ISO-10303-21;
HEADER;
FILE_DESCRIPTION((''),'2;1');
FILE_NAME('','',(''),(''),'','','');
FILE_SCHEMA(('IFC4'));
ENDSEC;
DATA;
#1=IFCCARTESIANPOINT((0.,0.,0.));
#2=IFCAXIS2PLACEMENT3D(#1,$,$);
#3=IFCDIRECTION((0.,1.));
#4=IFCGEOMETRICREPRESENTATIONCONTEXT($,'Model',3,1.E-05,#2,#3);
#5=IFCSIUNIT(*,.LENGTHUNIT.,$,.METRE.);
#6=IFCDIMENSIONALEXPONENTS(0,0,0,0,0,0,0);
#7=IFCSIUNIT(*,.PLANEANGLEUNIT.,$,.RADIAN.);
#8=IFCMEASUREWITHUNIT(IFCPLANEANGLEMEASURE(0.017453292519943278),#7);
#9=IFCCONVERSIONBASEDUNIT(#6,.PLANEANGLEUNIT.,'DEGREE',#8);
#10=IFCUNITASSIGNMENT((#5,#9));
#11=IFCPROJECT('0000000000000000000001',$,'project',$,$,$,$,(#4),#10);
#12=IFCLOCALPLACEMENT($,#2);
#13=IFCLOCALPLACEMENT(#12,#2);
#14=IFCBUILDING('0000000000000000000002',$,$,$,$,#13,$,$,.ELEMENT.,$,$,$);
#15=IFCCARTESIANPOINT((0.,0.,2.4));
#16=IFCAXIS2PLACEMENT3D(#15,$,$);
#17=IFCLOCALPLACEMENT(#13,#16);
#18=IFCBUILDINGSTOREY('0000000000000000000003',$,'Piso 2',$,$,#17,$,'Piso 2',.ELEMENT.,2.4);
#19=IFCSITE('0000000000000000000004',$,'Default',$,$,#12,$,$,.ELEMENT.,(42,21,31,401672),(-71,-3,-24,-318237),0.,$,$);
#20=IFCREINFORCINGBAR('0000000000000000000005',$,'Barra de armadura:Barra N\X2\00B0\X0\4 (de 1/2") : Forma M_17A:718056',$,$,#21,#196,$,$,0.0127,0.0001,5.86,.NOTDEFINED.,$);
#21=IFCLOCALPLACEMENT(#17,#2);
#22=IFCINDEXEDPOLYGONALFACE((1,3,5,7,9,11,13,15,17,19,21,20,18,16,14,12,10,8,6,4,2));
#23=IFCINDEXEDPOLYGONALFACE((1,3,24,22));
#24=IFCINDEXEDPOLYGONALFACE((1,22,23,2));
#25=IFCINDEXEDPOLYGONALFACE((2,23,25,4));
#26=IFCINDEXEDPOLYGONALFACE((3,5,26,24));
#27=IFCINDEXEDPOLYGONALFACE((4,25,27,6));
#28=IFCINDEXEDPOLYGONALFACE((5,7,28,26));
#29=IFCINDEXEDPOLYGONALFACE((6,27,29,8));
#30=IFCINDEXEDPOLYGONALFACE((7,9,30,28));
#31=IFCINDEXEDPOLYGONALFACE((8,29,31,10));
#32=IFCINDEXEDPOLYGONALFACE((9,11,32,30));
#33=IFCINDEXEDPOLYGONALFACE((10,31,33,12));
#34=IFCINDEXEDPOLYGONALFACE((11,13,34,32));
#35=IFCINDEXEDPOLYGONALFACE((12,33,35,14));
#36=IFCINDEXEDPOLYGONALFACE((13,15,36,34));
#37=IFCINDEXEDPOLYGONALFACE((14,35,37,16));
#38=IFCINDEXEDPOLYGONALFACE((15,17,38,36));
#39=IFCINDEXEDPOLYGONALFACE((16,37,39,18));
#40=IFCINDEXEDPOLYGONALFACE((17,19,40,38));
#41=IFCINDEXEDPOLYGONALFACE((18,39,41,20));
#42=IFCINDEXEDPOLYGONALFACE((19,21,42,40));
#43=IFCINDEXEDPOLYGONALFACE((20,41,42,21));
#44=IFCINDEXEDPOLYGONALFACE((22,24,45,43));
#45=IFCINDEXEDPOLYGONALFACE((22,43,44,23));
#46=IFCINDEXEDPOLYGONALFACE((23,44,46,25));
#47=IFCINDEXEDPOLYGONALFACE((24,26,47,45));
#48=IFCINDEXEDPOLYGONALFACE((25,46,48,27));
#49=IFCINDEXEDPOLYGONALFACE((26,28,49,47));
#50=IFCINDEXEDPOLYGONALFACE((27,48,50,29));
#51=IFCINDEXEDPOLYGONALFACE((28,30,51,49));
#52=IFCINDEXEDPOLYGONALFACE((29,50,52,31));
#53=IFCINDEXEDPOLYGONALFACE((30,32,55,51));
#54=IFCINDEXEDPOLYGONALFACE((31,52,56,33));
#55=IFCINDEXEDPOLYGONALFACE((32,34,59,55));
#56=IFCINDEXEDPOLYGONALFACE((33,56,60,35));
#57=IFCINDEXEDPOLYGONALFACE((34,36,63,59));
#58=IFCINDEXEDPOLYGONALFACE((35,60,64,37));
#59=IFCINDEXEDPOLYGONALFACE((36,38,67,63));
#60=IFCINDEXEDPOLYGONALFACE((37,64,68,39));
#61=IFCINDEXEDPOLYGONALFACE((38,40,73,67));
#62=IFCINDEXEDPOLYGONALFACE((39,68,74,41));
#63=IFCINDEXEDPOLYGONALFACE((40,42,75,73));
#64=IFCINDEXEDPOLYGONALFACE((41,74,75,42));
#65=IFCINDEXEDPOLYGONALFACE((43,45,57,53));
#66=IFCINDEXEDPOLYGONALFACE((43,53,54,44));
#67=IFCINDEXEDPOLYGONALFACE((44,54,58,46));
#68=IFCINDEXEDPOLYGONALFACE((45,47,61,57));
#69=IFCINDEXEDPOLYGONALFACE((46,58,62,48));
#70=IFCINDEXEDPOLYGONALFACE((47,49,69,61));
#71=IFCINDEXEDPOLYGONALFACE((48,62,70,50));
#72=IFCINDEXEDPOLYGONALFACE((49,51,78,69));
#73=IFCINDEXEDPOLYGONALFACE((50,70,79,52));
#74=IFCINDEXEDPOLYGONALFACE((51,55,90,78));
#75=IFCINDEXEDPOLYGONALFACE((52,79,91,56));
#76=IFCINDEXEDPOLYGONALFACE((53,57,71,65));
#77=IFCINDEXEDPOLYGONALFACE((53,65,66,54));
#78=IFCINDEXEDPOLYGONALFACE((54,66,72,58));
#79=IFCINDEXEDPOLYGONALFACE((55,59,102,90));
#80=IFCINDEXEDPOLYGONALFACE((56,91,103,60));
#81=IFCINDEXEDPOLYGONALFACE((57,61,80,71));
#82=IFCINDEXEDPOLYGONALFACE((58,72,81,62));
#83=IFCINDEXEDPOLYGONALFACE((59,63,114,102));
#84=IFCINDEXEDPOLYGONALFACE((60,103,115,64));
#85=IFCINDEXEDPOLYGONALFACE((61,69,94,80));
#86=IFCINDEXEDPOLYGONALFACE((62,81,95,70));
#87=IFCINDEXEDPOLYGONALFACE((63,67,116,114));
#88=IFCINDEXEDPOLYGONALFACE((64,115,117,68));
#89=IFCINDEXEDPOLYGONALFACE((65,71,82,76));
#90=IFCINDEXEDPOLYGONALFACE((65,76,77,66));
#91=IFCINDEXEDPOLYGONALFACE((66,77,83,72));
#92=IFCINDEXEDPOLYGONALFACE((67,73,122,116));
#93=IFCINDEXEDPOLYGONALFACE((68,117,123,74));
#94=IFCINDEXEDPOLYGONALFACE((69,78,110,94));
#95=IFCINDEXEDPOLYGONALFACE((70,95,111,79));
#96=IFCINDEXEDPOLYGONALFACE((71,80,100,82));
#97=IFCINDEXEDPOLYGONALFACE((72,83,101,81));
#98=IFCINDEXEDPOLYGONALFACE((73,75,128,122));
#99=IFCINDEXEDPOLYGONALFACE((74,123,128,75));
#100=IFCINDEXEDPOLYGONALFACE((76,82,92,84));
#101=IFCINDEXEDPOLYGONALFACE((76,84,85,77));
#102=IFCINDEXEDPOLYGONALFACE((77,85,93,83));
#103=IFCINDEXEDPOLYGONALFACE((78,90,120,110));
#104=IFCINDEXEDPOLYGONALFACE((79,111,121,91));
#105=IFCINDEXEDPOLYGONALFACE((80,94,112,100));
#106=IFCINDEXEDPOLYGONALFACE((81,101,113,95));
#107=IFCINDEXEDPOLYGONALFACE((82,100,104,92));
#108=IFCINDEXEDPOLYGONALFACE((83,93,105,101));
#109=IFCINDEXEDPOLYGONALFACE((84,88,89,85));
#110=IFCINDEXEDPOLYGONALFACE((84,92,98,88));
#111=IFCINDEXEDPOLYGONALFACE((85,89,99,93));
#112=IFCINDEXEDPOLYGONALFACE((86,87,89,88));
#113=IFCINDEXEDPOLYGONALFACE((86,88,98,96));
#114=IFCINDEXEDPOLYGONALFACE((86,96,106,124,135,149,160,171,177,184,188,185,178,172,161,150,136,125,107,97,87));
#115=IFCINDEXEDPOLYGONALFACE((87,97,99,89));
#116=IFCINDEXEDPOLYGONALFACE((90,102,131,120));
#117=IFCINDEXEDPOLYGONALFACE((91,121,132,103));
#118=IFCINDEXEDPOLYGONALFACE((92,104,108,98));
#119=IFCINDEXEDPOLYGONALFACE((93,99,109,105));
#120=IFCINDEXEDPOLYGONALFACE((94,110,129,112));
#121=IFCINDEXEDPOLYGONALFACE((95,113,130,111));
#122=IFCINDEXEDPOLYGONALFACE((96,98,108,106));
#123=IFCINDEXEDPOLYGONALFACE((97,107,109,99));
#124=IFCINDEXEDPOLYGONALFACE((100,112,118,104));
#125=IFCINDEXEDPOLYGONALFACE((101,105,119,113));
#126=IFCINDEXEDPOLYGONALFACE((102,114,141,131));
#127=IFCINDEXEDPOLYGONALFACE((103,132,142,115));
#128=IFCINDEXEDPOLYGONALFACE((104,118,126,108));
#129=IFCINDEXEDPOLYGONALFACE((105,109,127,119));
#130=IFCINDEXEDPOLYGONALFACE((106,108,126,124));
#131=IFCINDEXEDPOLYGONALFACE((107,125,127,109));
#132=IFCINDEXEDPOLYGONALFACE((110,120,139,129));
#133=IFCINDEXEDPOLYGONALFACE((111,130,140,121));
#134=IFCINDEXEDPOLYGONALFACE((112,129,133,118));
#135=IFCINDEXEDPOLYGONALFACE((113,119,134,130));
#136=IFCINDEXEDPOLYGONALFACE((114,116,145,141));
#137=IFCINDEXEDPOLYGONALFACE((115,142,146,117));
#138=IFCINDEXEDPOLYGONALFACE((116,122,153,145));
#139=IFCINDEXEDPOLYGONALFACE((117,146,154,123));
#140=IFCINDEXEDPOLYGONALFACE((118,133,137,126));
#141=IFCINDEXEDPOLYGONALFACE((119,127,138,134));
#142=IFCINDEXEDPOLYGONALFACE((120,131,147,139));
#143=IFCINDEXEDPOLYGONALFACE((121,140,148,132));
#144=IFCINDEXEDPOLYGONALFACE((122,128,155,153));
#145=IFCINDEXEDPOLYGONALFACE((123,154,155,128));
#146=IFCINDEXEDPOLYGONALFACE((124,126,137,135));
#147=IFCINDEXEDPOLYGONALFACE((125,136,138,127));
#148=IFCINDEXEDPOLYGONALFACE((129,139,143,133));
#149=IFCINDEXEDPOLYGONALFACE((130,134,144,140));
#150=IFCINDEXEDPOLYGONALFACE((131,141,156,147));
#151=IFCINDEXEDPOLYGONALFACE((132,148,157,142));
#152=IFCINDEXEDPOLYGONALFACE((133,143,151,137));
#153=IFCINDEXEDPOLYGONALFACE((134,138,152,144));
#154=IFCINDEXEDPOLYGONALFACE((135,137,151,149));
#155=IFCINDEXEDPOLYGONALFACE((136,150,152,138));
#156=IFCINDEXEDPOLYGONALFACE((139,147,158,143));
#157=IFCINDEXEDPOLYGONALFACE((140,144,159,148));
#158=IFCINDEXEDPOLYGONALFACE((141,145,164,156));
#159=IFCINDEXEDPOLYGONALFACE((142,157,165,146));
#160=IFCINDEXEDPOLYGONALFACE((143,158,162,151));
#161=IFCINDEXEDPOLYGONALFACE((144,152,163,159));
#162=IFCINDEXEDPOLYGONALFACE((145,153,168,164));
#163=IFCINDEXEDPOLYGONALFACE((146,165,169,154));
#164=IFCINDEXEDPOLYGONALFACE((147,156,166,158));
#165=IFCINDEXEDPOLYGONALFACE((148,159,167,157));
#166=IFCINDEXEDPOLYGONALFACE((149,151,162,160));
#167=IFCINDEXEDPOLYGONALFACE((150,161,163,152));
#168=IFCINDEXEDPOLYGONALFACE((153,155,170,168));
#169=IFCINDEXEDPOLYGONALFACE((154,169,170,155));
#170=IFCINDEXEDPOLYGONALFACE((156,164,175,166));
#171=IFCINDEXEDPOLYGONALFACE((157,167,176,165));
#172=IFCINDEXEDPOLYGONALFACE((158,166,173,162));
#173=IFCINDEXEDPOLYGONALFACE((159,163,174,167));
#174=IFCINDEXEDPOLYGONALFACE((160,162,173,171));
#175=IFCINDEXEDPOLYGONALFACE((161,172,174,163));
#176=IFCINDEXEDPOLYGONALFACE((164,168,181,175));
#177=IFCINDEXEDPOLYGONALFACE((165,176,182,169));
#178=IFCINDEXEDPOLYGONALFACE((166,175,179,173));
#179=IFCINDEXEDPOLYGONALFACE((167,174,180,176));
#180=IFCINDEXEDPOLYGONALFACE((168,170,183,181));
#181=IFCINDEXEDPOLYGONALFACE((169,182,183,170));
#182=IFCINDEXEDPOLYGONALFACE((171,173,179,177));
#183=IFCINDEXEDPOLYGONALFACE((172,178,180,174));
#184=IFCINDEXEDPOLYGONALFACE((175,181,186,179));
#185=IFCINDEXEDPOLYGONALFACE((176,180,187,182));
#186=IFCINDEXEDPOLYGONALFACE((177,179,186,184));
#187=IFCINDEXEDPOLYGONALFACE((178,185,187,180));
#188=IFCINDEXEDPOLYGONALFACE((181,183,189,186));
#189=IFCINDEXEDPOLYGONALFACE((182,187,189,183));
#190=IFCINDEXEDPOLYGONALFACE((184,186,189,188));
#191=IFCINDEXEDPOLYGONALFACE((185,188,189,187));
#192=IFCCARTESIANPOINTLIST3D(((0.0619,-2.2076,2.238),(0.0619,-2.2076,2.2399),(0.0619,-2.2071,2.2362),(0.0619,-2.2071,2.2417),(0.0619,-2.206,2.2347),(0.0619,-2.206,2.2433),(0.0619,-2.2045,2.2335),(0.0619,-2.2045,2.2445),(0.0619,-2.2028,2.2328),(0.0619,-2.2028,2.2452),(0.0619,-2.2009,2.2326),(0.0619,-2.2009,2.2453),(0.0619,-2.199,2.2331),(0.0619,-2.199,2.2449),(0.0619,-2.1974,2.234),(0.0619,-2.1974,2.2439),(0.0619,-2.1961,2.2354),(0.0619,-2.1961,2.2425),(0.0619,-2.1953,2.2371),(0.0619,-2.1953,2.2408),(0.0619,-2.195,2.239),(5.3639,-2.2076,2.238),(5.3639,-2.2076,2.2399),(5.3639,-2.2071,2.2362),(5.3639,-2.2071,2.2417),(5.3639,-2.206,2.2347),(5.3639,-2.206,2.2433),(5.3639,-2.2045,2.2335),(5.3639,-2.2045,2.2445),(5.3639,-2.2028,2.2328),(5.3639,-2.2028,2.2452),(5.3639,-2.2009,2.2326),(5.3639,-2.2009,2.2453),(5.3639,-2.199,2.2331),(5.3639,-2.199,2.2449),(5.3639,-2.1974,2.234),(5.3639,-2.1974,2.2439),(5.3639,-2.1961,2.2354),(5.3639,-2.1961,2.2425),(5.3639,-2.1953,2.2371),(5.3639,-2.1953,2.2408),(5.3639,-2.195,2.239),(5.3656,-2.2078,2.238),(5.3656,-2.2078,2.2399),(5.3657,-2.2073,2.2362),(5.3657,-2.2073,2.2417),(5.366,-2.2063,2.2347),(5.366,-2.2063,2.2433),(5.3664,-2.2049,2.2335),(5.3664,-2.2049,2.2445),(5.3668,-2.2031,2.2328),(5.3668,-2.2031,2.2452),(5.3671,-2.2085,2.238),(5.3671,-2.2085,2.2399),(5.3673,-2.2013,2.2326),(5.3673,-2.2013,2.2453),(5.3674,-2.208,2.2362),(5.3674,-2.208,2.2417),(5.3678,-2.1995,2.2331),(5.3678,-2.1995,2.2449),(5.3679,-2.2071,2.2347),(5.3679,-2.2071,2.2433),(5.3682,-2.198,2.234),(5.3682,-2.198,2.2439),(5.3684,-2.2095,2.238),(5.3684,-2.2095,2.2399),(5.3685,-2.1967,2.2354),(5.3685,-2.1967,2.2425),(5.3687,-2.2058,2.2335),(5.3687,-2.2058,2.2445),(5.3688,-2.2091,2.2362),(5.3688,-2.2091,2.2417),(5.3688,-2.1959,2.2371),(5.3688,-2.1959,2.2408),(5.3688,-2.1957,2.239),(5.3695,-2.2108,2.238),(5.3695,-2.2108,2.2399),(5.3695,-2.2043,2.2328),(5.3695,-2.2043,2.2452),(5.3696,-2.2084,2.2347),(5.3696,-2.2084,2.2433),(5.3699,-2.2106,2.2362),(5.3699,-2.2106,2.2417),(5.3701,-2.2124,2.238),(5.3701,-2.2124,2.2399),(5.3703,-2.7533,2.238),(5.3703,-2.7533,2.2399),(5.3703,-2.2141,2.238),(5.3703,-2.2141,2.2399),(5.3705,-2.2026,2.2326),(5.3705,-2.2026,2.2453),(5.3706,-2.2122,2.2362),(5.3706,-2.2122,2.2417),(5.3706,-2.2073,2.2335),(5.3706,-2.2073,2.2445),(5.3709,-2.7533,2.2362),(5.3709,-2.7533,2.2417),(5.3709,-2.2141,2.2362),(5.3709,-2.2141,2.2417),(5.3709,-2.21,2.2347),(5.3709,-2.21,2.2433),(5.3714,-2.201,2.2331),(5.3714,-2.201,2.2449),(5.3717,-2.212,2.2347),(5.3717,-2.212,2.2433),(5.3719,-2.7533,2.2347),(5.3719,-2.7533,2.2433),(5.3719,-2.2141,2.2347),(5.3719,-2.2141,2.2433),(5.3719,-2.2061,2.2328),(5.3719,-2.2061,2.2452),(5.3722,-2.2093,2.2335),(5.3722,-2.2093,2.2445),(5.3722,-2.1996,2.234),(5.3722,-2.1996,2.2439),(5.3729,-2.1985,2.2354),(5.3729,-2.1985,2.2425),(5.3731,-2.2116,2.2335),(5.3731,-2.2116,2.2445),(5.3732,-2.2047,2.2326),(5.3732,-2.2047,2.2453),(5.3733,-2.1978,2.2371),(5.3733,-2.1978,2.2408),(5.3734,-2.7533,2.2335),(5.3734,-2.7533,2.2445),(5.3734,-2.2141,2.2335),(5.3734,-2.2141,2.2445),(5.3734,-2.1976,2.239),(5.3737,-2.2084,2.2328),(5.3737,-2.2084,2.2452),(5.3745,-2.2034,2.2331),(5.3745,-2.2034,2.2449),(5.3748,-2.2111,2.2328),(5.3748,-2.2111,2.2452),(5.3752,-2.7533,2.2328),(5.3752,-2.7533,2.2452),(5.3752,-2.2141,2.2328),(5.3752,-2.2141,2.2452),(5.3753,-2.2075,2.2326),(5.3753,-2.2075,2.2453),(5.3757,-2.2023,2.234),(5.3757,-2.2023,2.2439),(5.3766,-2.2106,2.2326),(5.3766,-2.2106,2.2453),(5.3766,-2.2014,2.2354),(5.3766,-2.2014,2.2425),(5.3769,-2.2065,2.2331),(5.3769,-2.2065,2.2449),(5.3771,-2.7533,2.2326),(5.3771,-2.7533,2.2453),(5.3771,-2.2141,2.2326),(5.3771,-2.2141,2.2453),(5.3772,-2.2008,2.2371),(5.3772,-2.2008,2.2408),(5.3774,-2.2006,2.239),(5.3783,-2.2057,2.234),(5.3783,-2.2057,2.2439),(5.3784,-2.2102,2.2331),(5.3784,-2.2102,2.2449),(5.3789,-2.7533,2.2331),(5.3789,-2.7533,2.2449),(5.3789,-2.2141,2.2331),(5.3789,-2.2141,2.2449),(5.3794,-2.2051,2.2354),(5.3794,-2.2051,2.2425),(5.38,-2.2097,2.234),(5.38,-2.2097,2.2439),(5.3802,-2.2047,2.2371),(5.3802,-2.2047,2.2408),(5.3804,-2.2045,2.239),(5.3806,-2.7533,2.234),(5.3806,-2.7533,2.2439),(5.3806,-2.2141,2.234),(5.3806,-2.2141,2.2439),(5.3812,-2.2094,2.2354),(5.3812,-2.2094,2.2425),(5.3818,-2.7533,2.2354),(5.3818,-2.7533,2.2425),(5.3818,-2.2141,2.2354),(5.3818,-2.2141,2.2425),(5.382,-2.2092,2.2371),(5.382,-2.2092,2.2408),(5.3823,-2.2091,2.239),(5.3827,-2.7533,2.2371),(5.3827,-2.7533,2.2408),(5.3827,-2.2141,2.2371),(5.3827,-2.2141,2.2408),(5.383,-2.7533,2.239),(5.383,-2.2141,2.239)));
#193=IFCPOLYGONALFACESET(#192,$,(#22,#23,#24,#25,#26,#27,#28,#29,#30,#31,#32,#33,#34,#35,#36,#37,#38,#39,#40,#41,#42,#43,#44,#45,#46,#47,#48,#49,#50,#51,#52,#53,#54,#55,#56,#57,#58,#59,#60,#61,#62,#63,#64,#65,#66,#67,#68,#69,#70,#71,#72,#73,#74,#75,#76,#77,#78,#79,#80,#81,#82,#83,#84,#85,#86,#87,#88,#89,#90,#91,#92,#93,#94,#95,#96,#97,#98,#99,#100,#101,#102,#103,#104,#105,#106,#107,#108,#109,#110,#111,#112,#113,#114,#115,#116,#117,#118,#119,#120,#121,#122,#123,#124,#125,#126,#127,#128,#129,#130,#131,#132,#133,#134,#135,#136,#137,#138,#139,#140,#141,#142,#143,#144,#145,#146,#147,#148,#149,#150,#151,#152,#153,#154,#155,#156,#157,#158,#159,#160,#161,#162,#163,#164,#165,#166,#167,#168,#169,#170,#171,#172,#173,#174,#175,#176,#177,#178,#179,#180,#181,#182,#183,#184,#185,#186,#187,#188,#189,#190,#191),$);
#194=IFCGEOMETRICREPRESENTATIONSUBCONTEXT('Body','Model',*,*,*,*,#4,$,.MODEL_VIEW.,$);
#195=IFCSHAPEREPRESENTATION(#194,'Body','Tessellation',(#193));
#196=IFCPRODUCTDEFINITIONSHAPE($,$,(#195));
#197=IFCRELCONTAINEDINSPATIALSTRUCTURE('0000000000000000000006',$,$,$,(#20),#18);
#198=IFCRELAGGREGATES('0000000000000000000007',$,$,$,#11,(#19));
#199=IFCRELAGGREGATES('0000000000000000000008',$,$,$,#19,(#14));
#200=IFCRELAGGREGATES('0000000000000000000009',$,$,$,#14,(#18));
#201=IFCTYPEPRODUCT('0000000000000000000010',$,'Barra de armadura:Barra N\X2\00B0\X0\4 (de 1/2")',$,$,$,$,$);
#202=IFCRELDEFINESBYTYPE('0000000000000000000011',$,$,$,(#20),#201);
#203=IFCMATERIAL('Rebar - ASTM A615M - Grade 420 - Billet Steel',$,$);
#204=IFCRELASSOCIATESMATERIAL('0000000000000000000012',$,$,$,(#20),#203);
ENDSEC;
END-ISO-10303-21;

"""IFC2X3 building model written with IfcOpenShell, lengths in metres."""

from ifc_helpers import new_model, entity, si_unit, converted_unit, direction, frame, origin, place, context, subcontext, project, spatial, material, type_object, element, save


model = new_model("IFC2X3")

# Units and contexts
model_context = context("Model", 3, precision=1e-05, world=origin(), true_north=direction((0.0, 1.0)))
body_context = subcontext(model_context, "Body", "Model", "MODEL_VIEW")
ifc_project = project(units=[si_unit("LENGTHUNIT", "METRE"), converted_unit("PLANEANGLEUNIT", "DEGREE", entity("IfcPlaneAngleMeasure", 0.017453292519943278), si_unit("PLANEANGLEUNIT", "RADIAN"), dimensions=[0, 0, 0, 0, 0, 0, 0])], contexts=[model_context])

# Site, building, storey
site_placement = place(None, origin())
site = spatial("IfcSite", under=ifc_project, at=site_placement, Name="Default", CompositionType="ELEMENT", RefLatitude=(42, 21, 31, 401672), RefLongitude=(-71, -3, -24, -318237), RefElevation=0.0)
building_placement = place(site_placement, origin())
building = spatial("IfcBuilding", under=site, at=building_placement, CompositionType="ELEMENT")
storey_placement = place(building_placement, frame((0.0, 0.0, 2.4)))
storey = spatial("IfcBuildingStorey", under=building, at=storey_placement, Name="Piso 2", LongName="Piso 2", CompositionType="ELEMENT", Elevation=2.4)

# Reinforcing bar
ifc_material_1 = material(Name="Rebar - ASTM A615M - Grade 420 - Billet Steel")
type_product_1 = type_object("IfcTypeProduct", Name="Barra de armadura:Barra N°4 (de 1/2\")")
reinforcing_bar_1_placement = place(storey_placement, origin())
element("IfcReinforcingBar", 1, at=reinforcing_bar_1_placement, inside=storey, type_object=type_product_1, material=ifc_material_1, Name="Barra de armadura:Barra N°4 (de 1/2\") : Forma M_17A:718056", BarLength=5.86, BarRole="NOTDEFINED", CrossSectionArea=0.0001, NominalDiameter=0.0127, context=body_context, shape_type="AdvancedSweptSolid", body=[
    entity("IfcSweptDiskSolid", entity("IfcCompositeCurve", [entity("IfcCompositeCurveSegment", "CONTINUOUS", True, entity("IfcPolyline", [entity("IfcCartesianPoint", [0.0619, -2.2014, 2.239]), entity("IfcCartesianPoint", [5.3639, -2.2014, 2.239])])), entity("IfcCompositeCurveSegment", "CONTINUOUS", True, entity("IfcTrimmedCurve", entity("IfcCircle", entity("IfcAxis2Placement3D", entity("IfcCartesianPoint", [5.3639, -2.2141, 2.239]), entity("IfcDirection", [0.0, 0.0, -1.0]), entity("IfcDirection", [1.0, 0.0, 0.0])), 0.0127), [entity("IfcParameterValue", 270.0)], [entity("IfcParameterValue", 360.0)], True, "PARAMETER")), entity("IfcCompositeCurveSegment", "CONTINUOUS", True, entity("IfcPolyline", [entity("IfcCartesianPoint", [5.3766, -2.2141, 2.239]), entity("IfcCartesianPoint", [5.3766, -2.7533, 2.239])]))], False), 0.0063, None, 0.0, 92.0),
])

save(model, "model.ifc")
